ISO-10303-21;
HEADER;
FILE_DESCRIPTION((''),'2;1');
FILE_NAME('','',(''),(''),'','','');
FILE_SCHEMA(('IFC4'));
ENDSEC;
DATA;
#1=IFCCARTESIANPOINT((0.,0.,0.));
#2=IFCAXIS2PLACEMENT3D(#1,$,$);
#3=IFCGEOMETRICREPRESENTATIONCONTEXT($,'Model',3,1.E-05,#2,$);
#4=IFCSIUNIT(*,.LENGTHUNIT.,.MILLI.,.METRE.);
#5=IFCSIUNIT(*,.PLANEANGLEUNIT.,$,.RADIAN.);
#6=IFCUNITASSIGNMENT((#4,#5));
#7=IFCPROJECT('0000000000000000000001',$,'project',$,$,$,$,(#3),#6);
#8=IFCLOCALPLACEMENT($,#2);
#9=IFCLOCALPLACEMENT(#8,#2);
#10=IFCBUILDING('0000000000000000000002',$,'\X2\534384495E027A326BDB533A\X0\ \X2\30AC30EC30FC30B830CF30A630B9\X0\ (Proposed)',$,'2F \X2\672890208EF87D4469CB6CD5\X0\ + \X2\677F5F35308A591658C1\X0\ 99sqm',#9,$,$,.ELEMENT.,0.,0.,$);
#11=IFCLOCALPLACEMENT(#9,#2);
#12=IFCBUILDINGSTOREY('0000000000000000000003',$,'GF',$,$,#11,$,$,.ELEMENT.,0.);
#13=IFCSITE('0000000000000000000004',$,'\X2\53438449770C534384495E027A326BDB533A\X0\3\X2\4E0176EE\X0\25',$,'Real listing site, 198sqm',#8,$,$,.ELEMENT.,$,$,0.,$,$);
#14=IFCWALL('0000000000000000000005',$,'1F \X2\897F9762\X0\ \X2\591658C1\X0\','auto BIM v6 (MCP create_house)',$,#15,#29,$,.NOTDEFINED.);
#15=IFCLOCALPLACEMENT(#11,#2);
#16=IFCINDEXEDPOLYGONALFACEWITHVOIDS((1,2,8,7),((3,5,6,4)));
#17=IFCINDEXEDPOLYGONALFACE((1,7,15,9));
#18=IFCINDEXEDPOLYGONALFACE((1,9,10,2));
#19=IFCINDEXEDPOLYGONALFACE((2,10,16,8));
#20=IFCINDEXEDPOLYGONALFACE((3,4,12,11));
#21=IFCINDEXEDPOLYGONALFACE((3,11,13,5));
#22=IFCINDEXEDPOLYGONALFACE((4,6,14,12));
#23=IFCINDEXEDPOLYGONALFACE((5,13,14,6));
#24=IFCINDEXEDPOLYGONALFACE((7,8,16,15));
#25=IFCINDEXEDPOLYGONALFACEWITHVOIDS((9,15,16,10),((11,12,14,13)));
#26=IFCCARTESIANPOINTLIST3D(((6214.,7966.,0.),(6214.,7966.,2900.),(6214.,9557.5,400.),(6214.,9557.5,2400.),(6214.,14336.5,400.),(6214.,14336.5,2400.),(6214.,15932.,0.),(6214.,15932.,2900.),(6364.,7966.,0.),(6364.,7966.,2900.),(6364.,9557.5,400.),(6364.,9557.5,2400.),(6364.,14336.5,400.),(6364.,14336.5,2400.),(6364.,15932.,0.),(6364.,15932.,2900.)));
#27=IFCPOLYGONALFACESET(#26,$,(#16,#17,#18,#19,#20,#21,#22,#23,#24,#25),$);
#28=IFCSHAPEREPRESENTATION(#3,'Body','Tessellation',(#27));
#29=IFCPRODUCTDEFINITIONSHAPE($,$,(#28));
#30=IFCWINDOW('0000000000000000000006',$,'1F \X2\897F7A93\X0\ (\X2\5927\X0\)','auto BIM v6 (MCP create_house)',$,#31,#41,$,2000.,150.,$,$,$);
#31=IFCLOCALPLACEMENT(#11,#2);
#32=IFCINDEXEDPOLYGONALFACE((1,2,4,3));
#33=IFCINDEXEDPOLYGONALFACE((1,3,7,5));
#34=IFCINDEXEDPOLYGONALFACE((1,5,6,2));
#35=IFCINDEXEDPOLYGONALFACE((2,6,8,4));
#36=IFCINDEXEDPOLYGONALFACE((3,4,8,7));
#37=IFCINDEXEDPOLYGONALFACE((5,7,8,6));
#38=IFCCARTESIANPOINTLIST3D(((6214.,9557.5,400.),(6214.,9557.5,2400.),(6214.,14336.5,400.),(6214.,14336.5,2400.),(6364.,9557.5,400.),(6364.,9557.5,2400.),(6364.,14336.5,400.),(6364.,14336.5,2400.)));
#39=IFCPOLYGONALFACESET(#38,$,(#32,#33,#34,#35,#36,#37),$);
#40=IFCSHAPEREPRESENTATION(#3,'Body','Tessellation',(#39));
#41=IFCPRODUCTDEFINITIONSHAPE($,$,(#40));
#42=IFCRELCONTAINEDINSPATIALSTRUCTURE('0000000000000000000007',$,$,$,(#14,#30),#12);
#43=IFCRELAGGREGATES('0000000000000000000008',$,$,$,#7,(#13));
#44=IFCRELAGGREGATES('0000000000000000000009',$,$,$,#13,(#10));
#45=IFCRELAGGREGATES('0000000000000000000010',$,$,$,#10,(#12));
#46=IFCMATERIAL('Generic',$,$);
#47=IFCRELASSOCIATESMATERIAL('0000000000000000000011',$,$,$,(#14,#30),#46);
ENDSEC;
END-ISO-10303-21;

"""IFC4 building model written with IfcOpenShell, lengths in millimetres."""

from ifc_helpers import new_model, si_unit, frame, frame_2d, origin, place, context, project, spatial, rectangle, extrude, material, element, fill, save


model = new_model("IFC4")

# Units and contexts
model_context = context("Model", 3, precision=1e-05, world=origin())
ifc_project = project(units=[si_unit("LENGTHUNIT", "METRE", prefix="MILLI"), si_unit("PLANEANGLEUNIT", "RADIAN")], contexts=[model_context])

# Site, building, storey
site_placement = place(None, origin())
site = spatial("IfcSite", under=ifc_project, at=site_placement, Name="千葉県千葉市稲毛区3丁目25", ObjectType="Real listing site, 198sqm", CompositionType="ELEMENT", RefElevation=0.0)
building_placement = place(site_placement, origin())
building = spatial("IfcBuilding", under=site, at=building_placement, Name="千葉市稲毛区 ガレージハウス (Proposed)", ObjectType="2F 木造軸組構法 + 板張り外壁 99sqm", CompositionType="ELEMENT", ElevationOfRefHeight=0.0, ElevationOfTerrain=0.0)
storey_placement = place(building_placement, origin())
storey = spatial("IfcBuildingStorey", under=building, at=storey_placement, Name="GF", CompositionType="ELEMENT", Elevation=0.0)

# Shared definitions
ifc_material = material(Name="Generic")

# Wall, opening, window
wall_1_placement = place(storey_placement, frame((3107.0, 3983.0, 0.0)))
wall_1 = element("IfcWall", 1, at=wall_1_placement, inside=storey, material=ifc_material, Name="1F 西面 外壁", Description="auto BIM v6 (MCP create_house)", PredefinedType="NOTDEFINED", context=model_context, shape_type="SweptSolid", body=[
    extrude(rectangle(XDim=150.0, YDim=7966.0, at=frame_2d((75.0, 3983.0))), frame((3107.0, 3983.0, 0.0)), (0.0, 0.0, 1.0), 2900.0),
])
opening_1_placement = place(storey_placement, frame((3107.0, 4779.0, 200.0)))
opening_1 = element("IfcOpeningElement", 2, at=opening_1_placement, cuts=wall_1, PredefinedType="NOTDEFINED", context=model_context, shape_type="SweptSolid", body=[
    extrude(rectangle(XDim=150.0, YDim=4779.0, at=frame_2d((75.0, 2389.0))), frame((3107.0, 4779.0, 200.0)), (0.0, 0.0, 1.0), 2000.0),
])
window_1_placement = place(storey_placement, frame((3107.0, 4779.0, 200.0)))
window_1 = element("IfcWindow", 3, at=window_1_placement, inside=storey, material=ifc_material, Name="1F 西窓 (大)", Description="auto BIM v6 (MCP create_house)", OverallHeight=2000.0, OverallWidth=150.0, context=model_context, shape_type="SweptSolid", body=[
    extrude(rectangle(XDim=150.0, YDim=4779.0, at=frame_2d((75.0, 2389.0))), frame((3107.0, 4779.0, 200.0)), (0.0, 0.0, 1.0), 2000.0),
])
fill(opening_1, window_1)

save(model, "model.ifc")
